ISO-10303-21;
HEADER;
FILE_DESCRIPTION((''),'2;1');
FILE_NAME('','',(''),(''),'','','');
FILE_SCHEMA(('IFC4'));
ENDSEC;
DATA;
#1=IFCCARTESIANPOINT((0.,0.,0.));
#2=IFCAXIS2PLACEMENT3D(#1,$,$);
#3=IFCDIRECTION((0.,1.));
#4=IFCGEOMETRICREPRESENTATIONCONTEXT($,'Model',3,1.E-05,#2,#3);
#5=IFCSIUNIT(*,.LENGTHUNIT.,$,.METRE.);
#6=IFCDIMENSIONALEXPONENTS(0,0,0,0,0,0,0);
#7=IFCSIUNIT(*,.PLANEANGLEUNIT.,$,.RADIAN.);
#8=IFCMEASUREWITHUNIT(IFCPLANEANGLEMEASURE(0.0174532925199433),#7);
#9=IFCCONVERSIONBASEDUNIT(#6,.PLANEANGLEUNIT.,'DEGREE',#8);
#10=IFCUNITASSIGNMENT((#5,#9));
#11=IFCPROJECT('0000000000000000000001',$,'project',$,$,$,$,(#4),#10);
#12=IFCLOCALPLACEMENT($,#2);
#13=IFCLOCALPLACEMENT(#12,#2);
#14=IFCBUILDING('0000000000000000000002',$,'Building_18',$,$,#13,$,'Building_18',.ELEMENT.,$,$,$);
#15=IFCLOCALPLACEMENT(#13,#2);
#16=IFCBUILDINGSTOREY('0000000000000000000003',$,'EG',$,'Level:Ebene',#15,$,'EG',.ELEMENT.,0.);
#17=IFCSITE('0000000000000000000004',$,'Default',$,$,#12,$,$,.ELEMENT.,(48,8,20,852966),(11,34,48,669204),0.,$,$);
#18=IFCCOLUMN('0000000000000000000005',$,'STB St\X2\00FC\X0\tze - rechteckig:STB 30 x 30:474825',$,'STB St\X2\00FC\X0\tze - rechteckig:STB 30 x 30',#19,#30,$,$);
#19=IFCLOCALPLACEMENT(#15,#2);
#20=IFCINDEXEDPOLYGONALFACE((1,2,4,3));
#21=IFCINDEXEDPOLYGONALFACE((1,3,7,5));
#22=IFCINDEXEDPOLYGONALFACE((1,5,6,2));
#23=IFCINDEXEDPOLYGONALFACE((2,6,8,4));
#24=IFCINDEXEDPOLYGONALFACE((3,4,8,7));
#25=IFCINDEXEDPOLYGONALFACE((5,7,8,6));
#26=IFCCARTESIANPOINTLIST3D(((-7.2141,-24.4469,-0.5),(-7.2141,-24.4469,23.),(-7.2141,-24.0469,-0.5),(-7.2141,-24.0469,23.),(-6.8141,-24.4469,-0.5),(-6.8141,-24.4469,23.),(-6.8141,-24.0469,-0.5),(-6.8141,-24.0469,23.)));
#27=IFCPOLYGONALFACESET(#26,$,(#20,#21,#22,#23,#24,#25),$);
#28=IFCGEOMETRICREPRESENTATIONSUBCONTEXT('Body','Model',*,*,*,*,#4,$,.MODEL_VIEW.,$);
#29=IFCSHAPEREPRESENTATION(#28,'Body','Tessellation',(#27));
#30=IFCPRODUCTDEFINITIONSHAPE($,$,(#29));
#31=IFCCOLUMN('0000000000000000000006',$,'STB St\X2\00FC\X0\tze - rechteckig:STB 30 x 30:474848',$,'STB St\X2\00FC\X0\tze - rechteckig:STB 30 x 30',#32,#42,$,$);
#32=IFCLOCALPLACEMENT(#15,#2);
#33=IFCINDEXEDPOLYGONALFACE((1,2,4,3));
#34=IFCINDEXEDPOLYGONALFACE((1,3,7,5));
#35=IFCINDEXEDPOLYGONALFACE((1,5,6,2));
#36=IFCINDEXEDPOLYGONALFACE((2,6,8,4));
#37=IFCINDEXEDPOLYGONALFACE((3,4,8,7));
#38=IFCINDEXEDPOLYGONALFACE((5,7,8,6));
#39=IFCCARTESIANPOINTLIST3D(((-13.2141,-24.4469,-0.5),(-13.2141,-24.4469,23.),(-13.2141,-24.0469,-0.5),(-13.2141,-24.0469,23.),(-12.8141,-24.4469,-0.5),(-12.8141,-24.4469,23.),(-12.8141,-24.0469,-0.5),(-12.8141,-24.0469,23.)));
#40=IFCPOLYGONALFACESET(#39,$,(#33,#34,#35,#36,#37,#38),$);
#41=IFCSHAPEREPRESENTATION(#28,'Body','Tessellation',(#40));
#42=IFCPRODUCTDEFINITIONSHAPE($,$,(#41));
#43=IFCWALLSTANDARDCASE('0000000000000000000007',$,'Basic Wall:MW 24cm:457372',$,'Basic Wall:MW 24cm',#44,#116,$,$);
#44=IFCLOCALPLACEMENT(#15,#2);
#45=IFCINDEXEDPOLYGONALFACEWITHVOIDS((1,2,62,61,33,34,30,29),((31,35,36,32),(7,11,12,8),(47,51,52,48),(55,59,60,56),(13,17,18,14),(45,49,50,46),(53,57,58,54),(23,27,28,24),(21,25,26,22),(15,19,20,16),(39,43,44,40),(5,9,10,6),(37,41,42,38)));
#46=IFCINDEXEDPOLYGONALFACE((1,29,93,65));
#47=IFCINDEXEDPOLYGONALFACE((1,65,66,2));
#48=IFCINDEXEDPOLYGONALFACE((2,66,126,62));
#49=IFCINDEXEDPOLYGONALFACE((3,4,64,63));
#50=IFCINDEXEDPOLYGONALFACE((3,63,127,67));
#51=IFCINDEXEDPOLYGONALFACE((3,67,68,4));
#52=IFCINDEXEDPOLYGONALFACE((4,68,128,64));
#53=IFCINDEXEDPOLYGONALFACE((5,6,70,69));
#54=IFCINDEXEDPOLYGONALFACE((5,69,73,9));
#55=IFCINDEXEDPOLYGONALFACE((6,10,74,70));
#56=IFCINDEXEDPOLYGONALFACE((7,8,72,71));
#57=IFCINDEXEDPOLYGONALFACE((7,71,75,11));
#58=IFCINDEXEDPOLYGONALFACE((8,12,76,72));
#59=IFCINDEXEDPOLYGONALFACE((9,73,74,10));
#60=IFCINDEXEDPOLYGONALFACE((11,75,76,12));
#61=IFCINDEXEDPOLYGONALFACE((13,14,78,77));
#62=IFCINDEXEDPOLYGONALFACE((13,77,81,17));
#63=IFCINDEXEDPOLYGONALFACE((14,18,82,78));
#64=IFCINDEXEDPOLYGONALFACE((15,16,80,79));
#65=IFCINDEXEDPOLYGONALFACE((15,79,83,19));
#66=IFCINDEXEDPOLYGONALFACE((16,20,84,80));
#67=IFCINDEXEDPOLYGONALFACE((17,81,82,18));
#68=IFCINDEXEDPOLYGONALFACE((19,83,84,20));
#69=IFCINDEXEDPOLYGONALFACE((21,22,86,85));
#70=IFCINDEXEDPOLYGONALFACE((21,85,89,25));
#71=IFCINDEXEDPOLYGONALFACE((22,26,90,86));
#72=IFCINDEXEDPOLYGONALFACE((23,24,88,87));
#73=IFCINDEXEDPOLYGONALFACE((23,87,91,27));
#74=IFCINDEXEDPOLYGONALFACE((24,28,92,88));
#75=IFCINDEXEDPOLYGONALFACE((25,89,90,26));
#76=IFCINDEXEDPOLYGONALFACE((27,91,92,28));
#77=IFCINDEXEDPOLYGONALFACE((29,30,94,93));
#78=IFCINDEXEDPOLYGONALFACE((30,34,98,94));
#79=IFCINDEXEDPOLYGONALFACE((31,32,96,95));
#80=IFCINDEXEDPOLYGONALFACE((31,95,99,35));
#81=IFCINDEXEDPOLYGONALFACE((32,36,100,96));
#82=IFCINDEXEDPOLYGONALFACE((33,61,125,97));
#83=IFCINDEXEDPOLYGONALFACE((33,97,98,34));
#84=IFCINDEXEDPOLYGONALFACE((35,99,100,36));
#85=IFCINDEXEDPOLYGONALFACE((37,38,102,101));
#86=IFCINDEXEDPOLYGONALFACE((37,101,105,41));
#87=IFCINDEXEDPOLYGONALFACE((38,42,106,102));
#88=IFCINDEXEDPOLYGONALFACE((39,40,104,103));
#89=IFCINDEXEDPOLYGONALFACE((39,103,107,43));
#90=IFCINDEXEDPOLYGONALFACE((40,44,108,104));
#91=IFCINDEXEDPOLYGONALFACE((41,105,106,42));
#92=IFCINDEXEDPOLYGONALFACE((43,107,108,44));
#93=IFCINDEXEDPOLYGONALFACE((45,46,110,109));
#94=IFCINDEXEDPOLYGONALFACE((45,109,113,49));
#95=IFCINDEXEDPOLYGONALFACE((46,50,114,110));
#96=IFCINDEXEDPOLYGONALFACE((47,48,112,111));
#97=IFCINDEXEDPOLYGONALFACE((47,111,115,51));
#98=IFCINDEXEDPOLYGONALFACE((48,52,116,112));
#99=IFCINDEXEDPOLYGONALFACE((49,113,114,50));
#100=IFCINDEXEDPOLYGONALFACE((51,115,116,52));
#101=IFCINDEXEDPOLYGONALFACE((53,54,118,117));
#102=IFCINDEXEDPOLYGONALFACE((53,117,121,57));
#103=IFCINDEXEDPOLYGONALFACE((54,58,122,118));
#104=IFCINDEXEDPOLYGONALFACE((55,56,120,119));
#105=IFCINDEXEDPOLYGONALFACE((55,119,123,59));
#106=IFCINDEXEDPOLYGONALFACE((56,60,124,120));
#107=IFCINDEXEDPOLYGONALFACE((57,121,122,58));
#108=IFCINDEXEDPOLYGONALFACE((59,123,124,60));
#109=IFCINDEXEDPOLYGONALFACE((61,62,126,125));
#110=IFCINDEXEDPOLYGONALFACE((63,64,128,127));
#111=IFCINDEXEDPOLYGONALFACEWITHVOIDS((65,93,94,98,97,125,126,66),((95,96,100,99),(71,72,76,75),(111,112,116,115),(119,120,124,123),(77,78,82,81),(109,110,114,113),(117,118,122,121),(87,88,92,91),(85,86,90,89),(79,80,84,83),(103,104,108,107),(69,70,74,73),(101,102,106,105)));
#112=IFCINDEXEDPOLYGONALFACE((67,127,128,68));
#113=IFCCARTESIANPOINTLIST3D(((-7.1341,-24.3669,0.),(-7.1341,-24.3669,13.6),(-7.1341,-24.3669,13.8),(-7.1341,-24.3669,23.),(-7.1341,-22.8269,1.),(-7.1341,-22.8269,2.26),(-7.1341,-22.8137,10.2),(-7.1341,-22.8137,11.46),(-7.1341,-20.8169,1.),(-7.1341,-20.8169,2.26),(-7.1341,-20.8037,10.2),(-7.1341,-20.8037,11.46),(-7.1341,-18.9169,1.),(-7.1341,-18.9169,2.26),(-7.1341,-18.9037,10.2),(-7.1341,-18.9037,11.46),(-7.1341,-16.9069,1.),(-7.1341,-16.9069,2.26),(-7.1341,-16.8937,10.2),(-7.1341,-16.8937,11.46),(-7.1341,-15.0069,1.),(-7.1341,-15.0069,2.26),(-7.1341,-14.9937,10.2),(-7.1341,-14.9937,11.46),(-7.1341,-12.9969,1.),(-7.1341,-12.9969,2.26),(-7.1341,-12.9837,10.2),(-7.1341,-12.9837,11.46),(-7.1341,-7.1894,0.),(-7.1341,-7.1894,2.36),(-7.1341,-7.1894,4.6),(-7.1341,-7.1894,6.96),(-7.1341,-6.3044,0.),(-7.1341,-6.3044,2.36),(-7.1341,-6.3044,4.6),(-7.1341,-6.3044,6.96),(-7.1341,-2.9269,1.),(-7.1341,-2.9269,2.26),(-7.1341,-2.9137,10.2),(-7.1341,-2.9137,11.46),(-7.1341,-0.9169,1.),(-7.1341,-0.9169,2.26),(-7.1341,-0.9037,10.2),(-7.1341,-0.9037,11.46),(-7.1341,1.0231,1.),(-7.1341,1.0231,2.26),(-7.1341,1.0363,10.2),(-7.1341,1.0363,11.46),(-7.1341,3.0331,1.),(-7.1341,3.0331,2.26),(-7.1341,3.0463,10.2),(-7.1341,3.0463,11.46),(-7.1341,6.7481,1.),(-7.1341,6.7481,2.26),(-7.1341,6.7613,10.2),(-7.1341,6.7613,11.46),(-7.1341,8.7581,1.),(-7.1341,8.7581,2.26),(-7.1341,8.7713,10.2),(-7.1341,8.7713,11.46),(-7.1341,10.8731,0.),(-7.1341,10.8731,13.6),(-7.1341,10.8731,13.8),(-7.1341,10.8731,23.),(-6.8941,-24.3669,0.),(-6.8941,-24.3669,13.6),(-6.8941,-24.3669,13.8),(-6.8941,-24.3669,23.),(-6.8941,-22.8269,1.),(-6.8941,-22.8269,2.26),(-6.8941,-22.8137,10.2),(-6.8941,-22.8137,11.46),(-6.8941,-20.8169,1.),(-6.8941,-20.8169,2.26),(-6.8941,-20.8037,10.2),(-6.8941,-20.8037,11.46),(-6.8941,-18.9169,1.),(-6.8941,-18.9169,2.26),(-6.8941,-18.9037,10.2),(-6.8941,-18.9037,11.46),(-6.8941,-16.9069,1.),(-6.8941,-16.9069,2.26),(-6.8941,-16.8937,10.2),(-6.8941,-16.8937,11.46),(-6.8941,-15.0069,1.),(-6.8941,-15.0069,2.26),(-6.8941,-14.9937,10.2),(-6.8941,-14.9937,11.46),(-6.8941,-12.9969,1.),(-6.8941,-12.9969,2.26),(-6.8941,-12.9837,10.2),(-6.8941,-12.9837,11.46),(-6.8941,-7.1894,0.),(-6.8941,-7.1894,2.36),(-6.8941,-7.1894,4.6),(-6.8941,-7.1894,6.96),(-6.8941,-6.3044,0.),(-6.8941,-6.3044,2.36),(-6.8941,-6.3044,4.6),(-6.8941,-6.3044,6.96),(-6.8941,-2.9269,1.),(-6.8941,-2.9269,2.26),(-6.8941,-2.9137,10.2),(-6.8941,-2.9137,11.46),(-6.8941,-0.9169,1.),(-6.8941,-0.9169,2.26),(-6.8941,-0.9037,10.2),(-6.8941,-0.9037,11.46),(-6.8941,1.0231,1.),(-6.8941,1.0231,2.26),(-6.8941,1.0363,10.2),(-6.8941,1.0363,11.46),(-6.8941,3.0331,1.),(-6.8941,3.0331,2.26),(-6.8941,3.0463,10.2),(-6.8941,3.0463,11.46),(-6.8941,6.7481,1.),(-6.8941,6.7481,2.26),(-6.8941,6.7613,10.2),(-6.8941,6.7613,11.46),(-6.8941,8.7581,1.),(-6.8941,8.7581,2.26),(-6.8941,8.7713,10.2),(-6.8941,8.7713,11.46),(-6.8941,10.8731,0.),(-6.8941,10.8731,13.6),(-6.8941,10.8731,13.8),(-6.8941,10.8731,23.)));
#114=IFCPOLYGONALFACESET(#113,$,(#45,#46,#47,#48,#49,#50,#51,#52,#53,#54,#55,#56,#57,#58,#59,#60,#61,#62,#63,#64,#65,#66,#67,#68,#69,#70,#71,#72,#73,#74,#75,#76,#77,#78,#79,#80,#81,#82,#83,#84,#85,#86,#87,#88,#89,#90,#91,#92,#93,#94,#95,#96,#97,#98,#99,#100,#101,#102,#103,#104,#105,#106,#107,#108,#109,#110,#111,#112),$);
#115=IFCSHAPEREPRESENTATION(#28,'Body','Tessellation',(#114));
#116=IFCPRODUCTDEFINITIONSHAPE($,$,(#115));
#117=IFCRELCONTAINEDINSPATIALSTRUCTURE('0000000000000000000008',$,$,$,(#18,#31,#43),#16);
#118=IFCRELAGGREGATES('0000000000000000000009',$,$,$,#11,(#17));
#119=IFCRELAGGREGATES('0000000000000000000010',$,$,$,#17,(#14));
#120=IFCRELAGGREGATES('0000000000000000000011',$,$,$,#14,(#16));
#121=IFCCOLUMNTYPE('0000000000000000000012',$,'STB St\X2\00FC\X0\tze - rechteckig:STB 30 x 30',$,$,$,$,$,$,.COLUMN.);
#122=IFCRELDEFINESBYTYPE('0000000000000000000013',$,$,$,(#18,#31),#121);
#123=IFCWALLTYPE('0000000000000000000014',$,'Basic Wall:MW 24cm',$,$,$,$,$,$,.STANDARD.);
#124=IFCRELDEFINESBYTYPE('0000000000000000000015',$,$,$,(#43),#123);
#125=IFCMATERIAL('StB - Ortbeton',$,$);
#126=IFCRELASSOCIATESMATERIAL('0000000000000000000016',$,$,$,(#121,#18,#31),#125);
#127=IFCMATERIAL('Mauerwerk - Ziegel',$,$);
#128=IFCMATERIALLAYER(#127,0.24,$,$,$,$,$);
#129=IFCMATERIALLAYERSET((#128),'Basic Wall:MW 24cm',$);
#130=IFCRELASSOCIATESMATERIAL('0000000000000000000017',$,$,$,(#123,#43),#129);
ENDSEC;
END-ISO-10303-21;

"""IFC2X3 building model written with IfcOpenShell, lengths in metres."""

from ifc_helpers import new_model, entity, si_unit, converted_unit, direction, frame, frame_2d, origin, origin_2d_with_axis, place, context, subcontext, project, spatial, rectangle, extrude, source, transform, mapped, material, layer, layer_set, layer_usage, type_object, type_shapes, element, save


model = new_model("IFC2X3")

# Units and contexts
model_context = context("Model", 3, precision=1e-05, world=origin(), true_north=direction((0.0, 1.0)))
body_context = subcontext(model_context, "Body", "Model", "MODEL_VIEW")
ifc_project = project(units=[si_unit("LENGTHUNIT", "METRE"), converted_unit("PLANEANGLEUNIT", "DEGREE", entity("IfcPlaneAngleMeasure", 0.0174532925199433), si_unit("PLANEANGLEUNIT", "RADIAN"), dimensions=[0, 0, 0, 0, 0, 0, 0])], contexts=[model_context])

# Site, building, storey
site_placement = place(None, origin())
site = spatial("IfcSite", under=ifc_project, at=site_placement, Name="Default", CompositionType="ELEMENT", RefLatitude=(48, 8, 20, 852966), RefLongitude=(11, 34, 48, 669204), RefElevation=0.0)
building_placement = place(site_placement, origin())
building = spatial("IfcBuilding", under=site, at=building_placement, Name="Building_18", LongName="Building_18", CompositionType="ELEMENT")
storey_placement = place(building_placement, origin())
storey = spatial("IfcBuildingStorey", under=building, at=storey_placement, Name="EG", ObjectType="Level:Ebene", LongName="EG", CompositionType="ELEMENT", Elevation=0.0)

# Columns
ifc_material_1 = material(Name="StB - Ortbeton")
column_type = type_object("IfcColumnType", Name="STB Stütze - rechteckig:STB 30 x 30", PredefinedType="COLUMN", material=ifc_material_1)
shared_shape = source(origin(), body_context, "Body", "SweptSolid", [
    extrude(rectangle(XDim=0.4, YDim=0.4, at=origin_2d_with_axis()), frame((0.0, 0.0, -0.5), z_axis=(0.0, 0.0, 1.0), x_axis=(-1.0, 0.0, 0.0)), (0.0, 0.0, 1.0), 23.5),
])
type_shapes(column_type, [shared_shape])
for number, where, name in (
    (1, (-7.0141, -24.2469, 0.0), "STB Stütze - rechteckig:STB 30 x 30:474825"),
    (2, (-13.0141, -24.2469, 0.0), "STB Stütze - rechteckig:STB 30 x 30:474848"),
):
    element("IfcColumn", number, at=place(storey_placement, frame(where)), inside=storey, type_object=column_type, material=ifc_material_1, Name=name, ObjectType="STB Stütze - rechteckig:STB 30 x 30", context=body_context, shape_type="MappedRepresentation", body=[
        mapped(shared_shape, transform((0.0, 0.0, 0.0), scale=1.0)),
    ])

# Wall, openings
ifc_material_2 = material(Name="Mauerwerk - Ziegel")
ifc_layer = layer(ifc_material_2, 0.24)
ifc_layer_set = layer_set([ifc_layer], Name="Basic Wall:MW 24cm")
ifc_layer_usage_1 = layer_usage(ifc_layer_set, "AXIS2", "NEGATIVE", 0.12)
wall_type = type_object("IfcWallType", Name="Basic Wall:MW 24cm", PredefinedType="STANDARD", material=ifc_layer_set)
wall_1_placement = place(storey_placement, frame((-7.0141, -24.3669, 0.0), z_axis=(0.0, 0.0, 1.0), x_axis=(0.0, 1.0, 0.0)))
wall_1 = element("IfcWallStandardCase", 3, at=wall_1_placement, inside=storey, type_object=wall_type, material=ifc_layer_usage_1, Name="Basic Wall:MW 24cm:457372", ObjectType="Basic Wall:MW 24cm", context=body_context, shape_type="SweptSolid", body=[
    extrude(rectangle(XDim=35.24, YDim=0.24, at=frame_2d((17.62, 0.0), x_axis=(-1.0, 0.0))), origin(), (0.0, 0.0, 1.0), 23.0),
])
opening_1_placement = place(storey_placement, frame((-7.0141, -24.3669, 0.0), z_axis=(0.0, 0.0, 1.0), x_axis=(0.0, 1.0, 0.0)))
element("IfcOpeningElement", 4, at=opening_1_placement, cuts=wall_1, ObjectType="Opening", context=body_context, shape_type="SweptSolid", body=[
    extrude(rectangle(XDim=35.24, YDim=0.24, at=frame_2d((0.0, -0.04), x_axis=(1.0, 0.0))), frame((17.62, 0.04, 13.6)), (0.0, 0.0, 1.0), 0.2),
])
opening_2_placement = place(wall_1_placement, frame((18.0625, 0.12, 0.0)))
element("IfcOpeningElement", 5, at=opening_2_placement, cuts=wall_1, ObjectType="Opening", context=body_context, shape_type="SweptSolid", body=[
    extrude(rectangle(XDim=2.36, YDim=0.885, at=frame_2d((1.18, 0.4425), x_axis=(1.0, 0.0))), frame((0.0, 0.0, 0.0), z_axis=(0.0, -1.0, 0.0), x_axis=(0.0, 0.0, 1.0)), (0.0, 0.0, 1.0), 0.24),
])
opening_3_placement = place(wall_1_placement, frame((33.125, 0.12, 1.0)))
element("IfcOpeningElement", 6, at=opening_3_placement, cuts=wall_1, ObjectType="Opening", context=body_context, shape_type="SweptSolid", body=[
    extrude(rectangle(XDim=1.26, YDim=2.01, at=frame_2d((0.63, 1.005), x_axis=(1.0, 0.0))), frame((0.0, 0.0, 0.0), z_axis=(0.0, -1.0, 0.0), x_axis=(0.0, 0.0, 1.0)), (0.0, 0.0, 1.0), 0.24),
])
opening_4_placement = place(wall_1_placement, frame((25.39, -0.12, 1.0)))
element("IfcOpeningElement", 7, at=opening_4_placement, cuts=wall_1, ObjectType="Opening", context=body_context, shape_type="SweptSolid", body=[
    extrude(rectangle(XDim=1.26, YDim=2.01, at=frame_2d((0.63, 1.005), x_axis=(1.0, 0.0))), frame((0.0, 0.0, 0.0), z_axis=(0.0, 1.0, 0.0), x_axis=(0.0, 0.0, 1.0)), (0.0, 0.0, 1.0), 0.24),
])
opening_5_placement = place(wall_1_placement, frame((23.45, 0.12, 1.0)))
element("IfcOpeningElement", 8, at=opening_5_placement, cuts=wall_1, ObjectType="Opening", context=body_context, shape_type="SweptSolid", body=[
    extrude(rectangle(XDim=1.26, YDim=2.01, at=frame_2d((0.63, 1.005), x_axis=(1.0, 0.0))), frame((0.0, 0.0, 0.0), z_axis=(0.0, -1.0, 0.0), x_axis=(0.0, 0.0, 1.0)), (0.0, 0.0, 1.0), 0.24),
])
opening_6_placement = place(wall_1_placement, frame((3.55, 0.12, 1.0)))
element("IfcOpeningElement", 9, at=opening_6_placement, cuts=wall_1, ObjectType="Opening", context=body_context, shape_type="SweptSolid", body=[
    extrude(rectangle(XDim=1.26, YDim=2.01, at=frame_2d((0.63, 1.005), x_axis=(1.0, 0.0))), frame((0.0, 0.0, 0.0), z_axis=(0.0, -1.0, 0.0), x_axis=(0.0, 0.0, 1.0)), (0.0, 0.0, 1.0), 0.24),
])
opening_7_placement = place(wall_1_placement, frame((7.46, 0.12, 1.0)))
element("IfcOpeningElement", 10, at=opening_7_placement, cuts=wall_1, ObjectType="Opening", context=body_context, shape_type="SweptSolid", body=[
    extrude(rectangle(XDim=1.26, YDim=2.01, at=frame_2d((0.63, 1.005), x_axis=(1.0, 0.0))), frame((0.0, 0.0, 0.0), z_axis=(0.0, -1.0, 0.0), x_axis=(0.0, 0.0, 1.0)), (0.0, 0.0, 1.0), 0.24),
])
opening_8_placement = place(wall_1_placement, frame((11.37, 0.12, 1.0)))
element("IfcOpeningElement", 11, at=opening_8_placement, cuts=wall_1, ObjectType="Opening", context=body_context, shape_type="SweptSolid", body=[
    extrude(rectangle(XDim=1.26, YDim=2.01, at=frame_2d((0.63, 1.005), x_axis=(1.0, 0.0))), frame((0.0, 0.0, 0.0), z_axis=(0.0, -1.0, 0.0), x_axis=(0.0, 0.0, 1.0)), (0.0, 0.0, 1.0), 0.24),
])
opening_9_placement = place(wall_1_placement, frame((33.1382, 0.12, 10.2)))
element("IfcOpeningElement", 12, at=opening_9_placement, cuts=wall_1, ObjectType="Opening", context=body_context, shape_type="SweptSolid", body=[
    extrude(rectangle(XDim=1.26, YDim=2.01, at=frame_2d((0.63, 1.005), x_axis=(1.0, 0.0))), frame((0.0, 0.0, 0.0), z_axis=(0.0, -1.0, 0.0), x_axis=(0.0, 0.0, 1.0)), (0.0, 0.0, 1.0), 0.24),
])
opening_10_placement = place(wall_1_placement, frame((25.4032, -0.12, 10.2)))
element("IfcOpeningElement", 13, at=opening_10_placement, cuts=wall_1, ObjectType="Opening", context=body_context, shape_type="SweptSolid", body=[
    extrude(rectangle(XDim=1.26, YDim=2.01, at=frame_2d((0.63, 1.005), x_axis=(1.0, 0.0))), frame((0.0, 0.0, 0.0), z_axis=(0.0, 1.0, 0.0), x_axis=(0.0, 0.0, 1.0)), (0.0, 0.0, 1.0), 0.24),
])
opening_11_placement = place(wall_1_placement, frame((23.4632, 0.12, 10.2)))
element("IfcOpeningElement", 14, at=opening_11_placement, cuts=wall_1, ObjectType="Opening", context=body_context, shape_type="SweptSolid", body=[
    extrude(rectangle(XDim=1.26, YDim=2.01, at=frame_2d((0.63, 1.005), x_axis=(1.0, 0.0))), frame((0.0, 0.0, 0.0), z_axis=(0.0, -1.0, 0.0), x_axis=(0.0, 0.0, 1.0)), (0.0, 0.0, 1.0), 0.24),
])
opening_12_placement = place(wall_1_placement, frame((3.5632, 0.12, 10.2)))
element("IfcOpeningElement", 15, at=opening_12_placement, cuts=wall_1, ObjectType="Opening", context=body_context, shape_type="SweptSolid", body=[
    extrude(rectangle(XDim=1.26, YDim=2.01, at=frame_2d((0.63, 1.005), x_axis=(1.0, 0.0))), frame((0.0, 0.0, 0.0), z_axis=(0.0, -1.0, 0.0), x_axis=(0.0, 0.0, 1.0)), (0.0, 0.0, 1.0), 0.24),
])
opening_13_placement = place(wall_1_placement, frame((7.4732, 0.12, 10.2)))
element("IfcOpeningElement", 16, at=opening_13_placement, cuts=wall_1, ObjectType="Opening", context=body_context, shape_type="SweptSolid", body=[
    extrude(rectangle(XDim=1.26, YDim=2.01, at=frame_2d((0.63, 1.005), x_axis=(1.0, 0.0))), frame((0.0, 0.0, 0.0), z_axis=(0.0, -1.0, 0.0), x_axis=(0.0, 0.0, 1.0)), (0.0, 0.0, 1.0), 0.24),
])
opening_14_placement = place(wall_1_placement, frame((11.3832, 0.12, 10.2)))
element("IfcOpeningElement", 17, at=opening_14_placement, cuts=wall_1, ObjectType="Opening", context=body_context, shape_type="SweptSolid", body=[
    extrude(rectangle(XDim=1.26, YDim=2.01, at=frame_2d((0.63, 1.005), x_axis=(1.0, 0.0))), frame((0.0, 0.0, 0.0), z_axis=(0.0, -1.0, 0.0), x_axis=(0.0, 0.0, 1.0)), (0.0, 0.0, 1.0), 0.24),
])
opening_15_placement = place(wall_1_placement, frame((18.0625, 0.12, 4.6)))
element("IfcOpeningElement", 18, at=opening_15_placement, cuts=wall_1, ObjectType="Opening", context=body_context, shape_type="SweptSolid", body=[
    extrude(rectangle(XDim=2.36, YDim=0.885, at=frame_2d((1.18, 0.4425), x_axis=(1.0, 0.0))), frame((0.0, 0.0, 0.0), z_axis=(0.0, -1.0, 0.0), x_axis=(0.0, 0.0, 1.0)), (0.0, 0.0, 1.0), 0.24),
])

save(model, "model.ifc")
